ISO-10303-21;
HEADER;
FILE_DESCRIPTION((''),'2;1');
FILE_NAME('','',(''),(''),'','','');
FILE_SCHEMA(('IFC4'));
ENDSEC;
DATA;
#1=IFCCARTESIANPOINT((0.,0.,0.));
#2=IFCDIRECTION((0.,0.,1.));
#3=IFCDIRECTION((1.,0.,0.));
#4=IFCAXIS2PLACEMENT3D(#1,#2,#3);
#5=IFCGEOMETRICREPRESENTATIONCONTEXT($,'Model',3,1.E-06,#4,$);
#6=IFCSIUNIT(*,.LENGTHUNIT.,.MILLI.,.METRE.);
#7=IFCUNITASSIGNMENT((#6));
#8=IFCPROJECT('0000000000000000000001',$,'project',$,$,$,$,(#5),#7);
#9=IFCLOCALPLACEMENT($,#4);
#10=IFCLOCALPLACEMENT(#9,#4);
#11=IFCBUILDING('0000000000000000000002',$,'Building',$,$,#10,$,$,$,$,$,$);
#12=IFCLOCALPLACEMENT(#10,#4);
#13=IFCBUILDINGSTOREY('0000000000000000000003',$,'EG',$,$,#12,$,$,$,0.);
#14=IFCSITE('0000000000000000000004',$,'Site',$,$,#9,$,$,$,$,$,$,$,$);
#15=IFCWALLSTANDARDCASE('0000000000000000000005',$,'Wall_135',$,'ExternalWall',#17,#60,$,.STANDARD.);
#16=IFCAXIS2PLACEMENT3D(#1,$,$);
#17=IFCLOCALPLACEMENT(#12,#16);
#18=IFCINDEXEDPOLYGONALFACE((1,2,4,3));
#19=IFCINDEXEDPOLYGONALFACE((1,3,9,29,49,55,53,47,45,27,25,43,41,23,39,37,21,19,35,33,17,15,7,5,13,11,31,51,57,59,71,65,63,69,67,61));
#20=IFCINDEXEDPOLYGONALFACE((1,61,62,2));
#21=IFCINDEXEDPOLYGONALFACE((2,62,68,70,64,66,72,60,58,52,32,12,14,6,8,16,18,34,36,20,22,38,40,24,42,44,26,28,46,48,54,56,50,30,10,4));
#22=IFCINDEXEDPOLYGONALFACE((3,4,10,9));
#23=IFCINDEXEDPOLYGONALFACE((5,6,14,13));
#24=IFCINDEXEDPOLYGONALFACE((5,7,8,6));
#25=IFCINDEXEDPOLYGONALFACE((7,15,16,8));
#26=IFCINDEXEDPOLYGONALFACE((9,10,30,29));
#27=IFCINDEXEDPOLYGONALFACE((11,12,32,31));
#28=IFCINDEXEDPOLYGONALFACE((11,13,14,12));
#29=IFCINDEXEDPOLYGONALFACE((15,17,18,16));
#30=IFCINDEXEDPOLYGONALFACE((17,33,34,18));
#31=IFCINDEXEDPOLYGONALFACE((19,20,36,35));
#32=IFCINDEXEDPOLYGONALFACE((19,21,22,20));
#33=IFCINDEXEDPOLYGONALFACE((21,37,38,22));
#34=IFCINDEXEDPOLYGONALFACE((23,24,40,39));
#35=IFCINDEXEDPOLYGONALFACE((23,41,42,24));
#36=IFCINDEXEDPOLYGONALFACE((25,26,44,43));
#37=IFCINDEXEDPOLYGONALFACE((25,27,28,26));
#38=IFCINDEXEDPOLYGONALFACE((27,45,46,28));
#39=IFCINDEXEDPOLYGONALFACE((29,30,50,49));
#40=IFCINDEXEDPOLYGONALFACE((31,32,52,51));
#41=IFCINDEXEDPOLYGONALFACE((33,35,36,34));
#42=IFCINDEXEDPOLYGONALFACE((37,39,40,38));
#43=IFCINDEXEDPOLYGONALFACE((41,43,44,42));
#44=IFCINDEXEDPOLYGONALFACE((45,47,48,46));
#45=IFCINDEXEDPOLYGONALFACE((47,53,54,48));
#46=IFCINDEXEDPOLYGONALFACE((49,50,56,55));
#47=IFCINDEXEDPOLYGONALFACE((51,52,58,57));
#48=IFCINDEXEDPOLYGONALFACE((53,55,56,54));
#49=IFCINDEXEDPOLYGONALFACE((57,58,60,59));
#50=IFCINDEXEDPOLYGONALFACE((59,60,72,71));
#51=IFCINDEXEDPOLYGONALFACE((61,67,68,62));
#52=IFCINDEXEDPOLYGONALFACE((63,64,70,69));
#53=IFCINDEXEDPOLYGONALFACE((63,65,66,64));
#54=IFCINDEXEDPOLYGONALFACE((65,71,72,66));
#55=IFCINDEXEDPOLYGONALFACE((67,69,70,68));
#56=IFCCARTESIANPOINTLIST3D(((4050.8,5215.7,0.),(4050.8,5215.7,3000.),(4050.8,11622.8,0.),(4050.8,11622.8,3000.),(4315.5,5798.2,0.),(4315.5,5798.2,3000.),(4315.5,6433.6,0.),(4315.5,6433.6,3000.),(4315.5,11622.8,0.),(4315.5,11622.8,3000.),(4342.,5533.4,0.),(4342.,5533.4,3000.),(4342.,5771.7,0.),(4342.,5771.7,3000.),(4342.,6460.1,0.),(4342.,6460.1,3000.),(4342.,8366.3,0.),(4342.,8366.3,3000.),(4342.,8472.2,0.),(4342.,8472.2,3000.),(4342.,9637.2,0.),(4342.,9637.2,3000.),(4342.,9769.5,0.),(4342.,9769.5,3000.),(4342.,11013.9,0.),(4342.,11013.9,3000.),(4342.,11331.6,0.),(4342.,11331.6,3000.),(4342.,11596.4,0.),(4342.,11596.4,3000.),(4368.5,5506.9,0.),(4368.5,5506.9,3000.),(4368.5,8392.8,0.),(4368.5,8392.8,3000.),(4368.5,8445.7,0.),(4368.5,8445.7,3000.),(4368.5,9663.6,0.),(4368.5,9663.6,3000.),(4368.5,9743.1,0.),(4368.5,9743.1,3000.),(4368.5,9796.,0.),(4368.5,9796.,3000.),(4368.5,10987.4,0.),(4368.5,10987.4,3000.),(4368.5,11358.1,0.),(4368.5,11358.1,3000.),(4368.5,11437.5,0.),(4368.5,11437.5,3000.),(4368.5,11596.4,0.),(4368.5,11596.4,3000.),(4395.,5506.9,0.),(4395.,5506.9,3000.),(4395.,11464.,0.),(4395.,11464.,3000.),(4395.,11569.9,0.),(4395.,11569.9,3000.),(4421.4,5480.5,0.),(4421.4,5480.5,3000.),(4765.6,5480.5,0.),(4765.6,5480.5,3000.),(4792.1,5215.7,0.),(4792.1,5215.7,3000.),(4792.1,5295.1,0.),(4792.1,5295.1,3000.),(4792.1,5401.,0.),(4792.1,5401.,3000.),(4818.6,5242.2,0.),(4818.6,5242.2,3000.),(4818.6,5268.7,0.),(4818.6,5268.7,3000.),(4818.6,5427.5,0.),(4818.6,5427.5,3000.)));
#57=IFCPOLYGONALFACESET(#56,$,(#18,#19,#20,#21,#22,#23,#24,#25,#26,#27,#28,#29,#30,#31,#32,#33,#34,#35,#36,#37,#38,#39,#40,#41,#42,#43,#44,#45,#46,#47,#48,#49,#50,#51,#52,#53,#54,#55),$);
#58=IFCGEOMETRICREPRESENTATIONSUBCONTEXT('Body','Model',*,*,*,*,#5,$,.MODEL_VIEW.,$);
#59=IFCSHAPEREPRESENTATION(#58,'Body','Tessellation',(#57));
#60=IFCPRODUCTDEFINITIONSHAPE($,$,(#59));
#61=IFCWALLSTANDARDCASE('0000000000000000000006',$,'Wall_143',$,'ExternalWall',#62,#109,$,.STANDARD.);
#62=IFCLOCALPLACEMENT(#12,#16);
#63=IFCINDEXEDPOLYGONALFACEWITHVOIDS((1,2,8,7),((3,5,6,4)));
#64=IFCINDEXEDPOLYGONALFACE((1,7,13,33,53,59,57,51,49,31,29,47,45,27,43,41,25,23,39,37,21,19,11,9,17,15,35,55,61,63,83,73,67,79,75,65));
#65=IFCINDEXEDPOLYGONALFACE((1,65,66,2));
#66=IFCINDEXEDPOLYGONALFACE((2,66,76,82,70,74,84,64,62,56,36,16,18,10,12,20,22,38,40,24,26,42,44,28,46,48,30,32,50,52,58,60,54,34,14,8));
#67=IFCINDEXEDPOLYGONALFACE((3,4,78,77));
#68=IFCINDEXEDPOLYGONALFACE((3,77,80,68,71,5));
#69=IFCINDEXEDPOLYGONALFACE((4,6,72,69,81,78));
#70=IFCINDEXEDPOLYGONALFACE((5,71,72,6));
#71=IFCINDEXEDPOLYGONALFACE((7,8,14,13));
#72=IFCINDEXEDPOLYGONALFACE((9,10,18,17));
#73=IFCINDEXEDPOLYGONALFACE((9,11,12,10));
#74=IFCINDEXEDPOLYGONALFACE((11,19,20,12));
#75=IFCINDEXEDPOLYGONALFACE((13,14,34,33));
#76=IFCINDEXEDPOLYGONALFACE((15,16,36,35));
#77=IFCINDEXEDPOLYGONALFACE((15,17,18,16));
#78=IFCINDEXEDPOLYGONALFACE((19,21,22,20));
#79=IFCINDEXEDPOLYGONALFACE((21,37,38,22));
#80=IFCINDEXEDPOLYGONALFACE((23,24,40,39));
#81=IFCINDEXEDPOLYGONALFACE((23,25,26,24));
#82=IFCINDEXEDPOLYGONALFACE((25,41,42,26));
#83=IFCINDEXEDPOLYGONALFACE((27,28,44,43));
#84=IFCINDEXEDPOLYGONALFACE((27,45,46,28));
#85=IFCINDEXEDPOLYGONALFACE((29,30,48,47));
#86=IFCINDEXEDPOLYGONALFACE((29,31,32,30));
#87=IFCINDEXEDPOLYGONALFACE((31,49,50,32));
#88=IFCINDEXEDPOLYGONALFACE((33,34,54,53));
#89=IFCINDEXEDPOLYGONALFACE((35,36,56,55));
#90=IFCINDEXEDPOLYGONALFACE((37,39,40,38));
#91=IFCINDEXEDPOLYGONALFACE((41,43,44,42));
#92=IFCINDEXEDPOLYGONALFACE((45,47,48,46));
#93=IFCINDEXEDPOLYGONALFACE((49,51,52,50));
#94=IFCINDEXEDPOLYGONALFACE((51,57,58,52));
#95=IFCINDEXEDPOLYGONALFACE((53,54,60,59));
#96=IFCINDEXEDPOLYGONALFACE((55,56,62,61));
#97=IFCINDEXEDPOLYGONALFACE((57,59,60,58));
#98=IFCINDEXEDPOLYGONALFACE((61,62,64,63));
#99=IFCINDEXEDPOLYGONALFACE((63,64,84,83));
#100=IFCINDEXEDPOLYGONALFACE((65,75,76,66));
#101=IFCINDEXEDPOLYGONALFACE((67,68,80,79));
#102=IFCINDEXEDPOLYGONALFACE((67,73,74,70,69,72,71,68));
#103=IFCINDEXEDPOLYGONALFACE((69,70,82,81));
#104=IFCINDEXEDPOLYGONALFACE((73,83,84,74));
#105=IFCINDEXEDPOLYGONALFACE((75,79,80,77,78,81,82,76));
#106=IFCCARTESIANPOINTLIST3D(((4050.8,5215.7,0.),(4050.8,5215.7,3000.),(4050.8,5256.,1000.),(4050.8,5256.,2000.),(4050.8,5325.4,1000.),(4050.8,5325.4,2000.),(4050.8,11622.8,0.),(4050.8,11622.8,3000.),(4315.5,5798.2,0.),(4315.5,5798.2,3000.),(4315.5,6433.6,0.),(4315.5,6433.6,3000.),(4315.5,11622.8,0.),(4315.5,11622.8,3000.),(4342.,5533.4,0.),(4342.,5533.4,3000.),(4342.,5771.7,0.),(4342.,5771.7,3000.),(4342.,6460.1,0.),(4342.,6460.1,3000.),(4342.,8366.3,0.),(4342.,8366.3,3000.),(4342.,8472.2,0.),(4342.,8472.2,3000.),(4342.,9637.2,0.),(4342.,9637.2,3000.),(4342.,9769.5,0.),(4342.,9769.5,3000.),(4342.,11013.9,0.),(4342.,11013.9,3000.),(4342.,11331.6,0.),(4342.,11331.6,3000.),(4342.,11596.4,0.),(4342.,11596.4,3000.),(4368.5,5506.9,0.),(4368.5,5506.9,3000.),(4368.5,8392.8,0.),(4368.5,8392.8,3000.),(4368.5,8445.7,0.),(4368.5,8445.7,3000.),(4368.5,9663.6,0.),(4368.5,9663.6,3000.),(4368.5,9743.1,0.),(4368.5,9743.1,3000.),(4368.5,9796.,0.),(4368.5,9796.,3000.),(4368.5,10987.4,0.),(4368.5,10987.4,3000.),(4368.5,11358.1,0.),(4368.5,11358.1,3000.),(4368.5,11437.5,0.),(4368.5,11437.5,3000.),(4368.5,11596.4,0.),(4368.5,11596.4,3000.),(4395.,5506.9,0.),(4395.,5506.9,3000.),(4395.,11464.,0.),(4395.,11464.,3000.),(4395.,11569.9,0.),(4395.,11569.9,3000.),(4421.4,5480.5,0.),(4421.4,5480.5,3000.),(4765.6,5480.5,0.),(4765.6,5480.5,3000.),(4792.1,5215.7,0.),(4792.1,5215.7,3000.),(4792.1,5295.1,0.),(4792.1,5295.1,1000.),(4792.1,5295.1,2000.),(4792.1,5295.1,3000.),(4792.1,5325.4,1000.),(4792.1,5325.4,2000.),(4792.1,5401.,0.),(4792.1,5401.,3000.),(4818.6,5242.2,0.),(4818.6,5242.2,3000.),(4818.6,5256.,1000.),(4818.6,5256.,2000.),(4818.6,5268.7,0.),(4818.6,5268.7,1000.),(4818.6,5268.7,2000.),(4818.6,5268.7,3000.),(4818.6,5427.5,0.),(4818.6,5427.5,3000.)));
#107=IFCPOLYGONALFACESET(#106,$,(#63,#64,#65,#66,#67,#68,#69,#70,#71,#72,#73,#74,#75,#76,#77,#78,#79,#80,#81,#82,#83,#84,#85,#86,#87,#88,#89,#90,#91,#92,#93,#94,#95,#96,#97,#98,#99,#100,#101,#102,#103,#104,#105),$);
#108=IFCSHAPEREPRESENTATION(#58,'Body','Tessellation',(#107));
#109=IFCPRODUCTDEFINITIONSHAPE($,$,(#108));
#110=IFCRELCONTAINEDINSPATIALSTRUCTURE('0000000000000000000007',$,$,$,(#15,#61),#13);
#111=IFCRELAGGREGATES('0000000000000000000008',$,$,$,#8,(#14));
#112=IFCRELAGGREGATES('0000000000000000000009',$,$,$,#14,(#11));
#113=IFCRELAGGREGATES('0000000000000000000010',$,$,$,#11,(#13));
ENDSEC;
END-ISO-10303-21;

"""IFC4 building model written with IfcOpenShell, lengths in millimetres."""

from ifc_helpers import new_model, si_unit, frame, origin_with_axes, place, context, subcontext, project, spatial, polyline, rectangle, outline, extrude, element, save


model = new_model("IFC4")

# Units and contexts
model_context = context("Model", 3, precision=1e-06, world=origin_with_axes())
body_context = subcontext(model_context, "Body", "Model", "MODEL_VIEW")
ifc_project = project(units=[si_unit("LENGTHUNIT", "METRE", prefix="MILLI")], contexts=[model_context])

# Site, building, storey
site_placement = place(None, origin_with_axes())
site = spatial("IfcSite", under=ifc_project, at=site_placement, Name="Site")
building_placement = place(site_placement, origin_with_axes())
building = spatial("IfcBuilding", under=site, at=building_placement, Name="Building")
storey_placement = place(building_placement, origin_with_axes())
storey = spatial("IfcBuildingStorey", under=building, at=storey_placement, Name="EG", Elevation=0.0)

# Wall
for number, where, z_axis, x_axis, name in (
    (1, (0.0, 0.0, 0.0), (0.0, 0.0, 1.0), (1.0, 0.0, 0.0), "Wall_135"),
):
    element("IfcWallStandardCase", number, at=place(storey_placement, frame(where, z_axis=z_axis, x_axis=x_axis)), inside=storey, Name=name, ObjectType="ExternalWall", PredefinedType="STANDARD", context=body_context, shape_type="SweptSolid", body=[
        extrude(outline(polyline([(4050.8, 5215.7, 0.0), (4050.8, 11622.8, 0.0), (4315.5, 11622.8, 0.0), (4342.0, 11596.4, 0.0), (4368.5, 11596.4, 0.0), (4395.0, 11569.9, 0.0), (4395.0, 11464.0, 0.0), (4368.5, 11437.5, 0.0), (4368.5, 11358.1, 0.0), (4342.0, 11331.6, 0.0), (4342.0, 11013.9, 0.0), (4368.5, 10987.4, 0.0), (4368.5, 9796.0, 0.0), (4342.0, 9769.5, 0.0), (4368.5, 9743.1, 0.0), (4368.5, 9663.6, 0.0), (4342.0, 9637.2, 0.0), (4342.0, 8472.2, 0.0), (4368.5, 8445.7, 0.0), (4368.5, 8392.8, 0.0), (4342.0, 8366.3, 0.0), (4342.0, 6460.1, 0.0), (4315.5, 6433.6, 0.0), (4315.5, 5798.2, 0.0), (4342.0, 5771.7, 0.0), (4342.0, 5533.4, 0.0), (4368.5, 5506.9, 0.0), (4395.0, 5506.9, 0.0), (4421.4, 5480.5, 0.0), (4765.6, 5480.5, 0.0), (4818.6, 5427.5, 0.0), (4792.1, 5401.0, 0.0), (4792.1, 5295.1, 0.0), (4818.6, 5268.7, 0.0), (4818.6, 5242.2, 0.0), (4792.1, 5215.7, 0.0), (4050.8, 5215.7, 0.0)])), origin_with_axes(), (0.0, 0.0, 1.0), 3000.0),
    ])

# Wall, opening
wall_1_placement = place(storey_placement, origin_with_axes())
wall_1 = element("IfcWallStandardCase", 2, at=wall_1_placement, inside=storey, Name="Wall_143", ObjectType="ExternalWall", PredefinedType="STANDARD", context=body_context, shape_type="SweptSolid", body=[
    extrude(outline(polyline([(4050.8, 5215.7, 0.0), (4050.8, 11622.8, 0.0), (4315.5, 11622.8, 0.0), (4342.0, 11596.4, 0.0), (4368.5, 11596.4, 0.0), (4395.0, 11569.9, 0.0), (4395.0, 11464.0, 0.0), (4368.5, 11437.5, 0.0), (4368.5, 11358.1, 0.0), (4342.0, 11331.6, 0.0), (4342.0, 11013.9, 0.0), (4368.5, 10987.4, 0.0), (4368.5, 9796.0, 0.0), (4342.0, 9769.5, 0.0), (4368.5, 9743.1, 0.0), (4368.5, 9663.6, 0.0), (4342.0, 9637.2, 0.0), (4342.0, 8472.2, 0.0), (4368.5, 8445.7, 0.0), (4368.5, 8392.8, 0.0), (4342.0, 8366.3, 0.0), (4342.0, 6460.1, 0.0), (4315.5, 6433.6, 0.0), (4315.5, 5798.2, 0.0), (4342.0, 5771.7, 0.0), (4342.0, 5533.4, 0.0), (4368.5, 5506.9, 0.0), (4395.0, 5506.9, 0.0), (4421.4, 5480.5, 0.0), (4765.6, 5480.5, 0.0), (4818.6, 5427.5, 0.0), (4792.1, 5401.0, 0.0), (4792.1, 5295.1, 0.0), (4818.6, 5268.7, 0.0), (4818.6, 5242.2, 0.0), (4792.1, 5215.7, 0.0), (4050.8, 5215.7, 0.0)])), origin_with_axes(), (0.0, 0.0, 1.0), 3000.0),
])
opening_1_placement = place(wall_1_placement, origin_with_axes())
element("IfcOpeningElement", 3, at=opening_1_placement, inside=storey, cuts=wall_1, context=body_context, shape_type="SweptSolid", body=[
    extrude(rectangle(XDim=2721.7, YDim=69.4), frame((4723.0, 5290.7, 1000.0), z_axis=(0.0, 0.0, 1.0), x_axis=(1.0, 0.0, 0.0)), (0.0, 0.0, 1.0), 1000.0),
])

save(model, "model.ifc")
